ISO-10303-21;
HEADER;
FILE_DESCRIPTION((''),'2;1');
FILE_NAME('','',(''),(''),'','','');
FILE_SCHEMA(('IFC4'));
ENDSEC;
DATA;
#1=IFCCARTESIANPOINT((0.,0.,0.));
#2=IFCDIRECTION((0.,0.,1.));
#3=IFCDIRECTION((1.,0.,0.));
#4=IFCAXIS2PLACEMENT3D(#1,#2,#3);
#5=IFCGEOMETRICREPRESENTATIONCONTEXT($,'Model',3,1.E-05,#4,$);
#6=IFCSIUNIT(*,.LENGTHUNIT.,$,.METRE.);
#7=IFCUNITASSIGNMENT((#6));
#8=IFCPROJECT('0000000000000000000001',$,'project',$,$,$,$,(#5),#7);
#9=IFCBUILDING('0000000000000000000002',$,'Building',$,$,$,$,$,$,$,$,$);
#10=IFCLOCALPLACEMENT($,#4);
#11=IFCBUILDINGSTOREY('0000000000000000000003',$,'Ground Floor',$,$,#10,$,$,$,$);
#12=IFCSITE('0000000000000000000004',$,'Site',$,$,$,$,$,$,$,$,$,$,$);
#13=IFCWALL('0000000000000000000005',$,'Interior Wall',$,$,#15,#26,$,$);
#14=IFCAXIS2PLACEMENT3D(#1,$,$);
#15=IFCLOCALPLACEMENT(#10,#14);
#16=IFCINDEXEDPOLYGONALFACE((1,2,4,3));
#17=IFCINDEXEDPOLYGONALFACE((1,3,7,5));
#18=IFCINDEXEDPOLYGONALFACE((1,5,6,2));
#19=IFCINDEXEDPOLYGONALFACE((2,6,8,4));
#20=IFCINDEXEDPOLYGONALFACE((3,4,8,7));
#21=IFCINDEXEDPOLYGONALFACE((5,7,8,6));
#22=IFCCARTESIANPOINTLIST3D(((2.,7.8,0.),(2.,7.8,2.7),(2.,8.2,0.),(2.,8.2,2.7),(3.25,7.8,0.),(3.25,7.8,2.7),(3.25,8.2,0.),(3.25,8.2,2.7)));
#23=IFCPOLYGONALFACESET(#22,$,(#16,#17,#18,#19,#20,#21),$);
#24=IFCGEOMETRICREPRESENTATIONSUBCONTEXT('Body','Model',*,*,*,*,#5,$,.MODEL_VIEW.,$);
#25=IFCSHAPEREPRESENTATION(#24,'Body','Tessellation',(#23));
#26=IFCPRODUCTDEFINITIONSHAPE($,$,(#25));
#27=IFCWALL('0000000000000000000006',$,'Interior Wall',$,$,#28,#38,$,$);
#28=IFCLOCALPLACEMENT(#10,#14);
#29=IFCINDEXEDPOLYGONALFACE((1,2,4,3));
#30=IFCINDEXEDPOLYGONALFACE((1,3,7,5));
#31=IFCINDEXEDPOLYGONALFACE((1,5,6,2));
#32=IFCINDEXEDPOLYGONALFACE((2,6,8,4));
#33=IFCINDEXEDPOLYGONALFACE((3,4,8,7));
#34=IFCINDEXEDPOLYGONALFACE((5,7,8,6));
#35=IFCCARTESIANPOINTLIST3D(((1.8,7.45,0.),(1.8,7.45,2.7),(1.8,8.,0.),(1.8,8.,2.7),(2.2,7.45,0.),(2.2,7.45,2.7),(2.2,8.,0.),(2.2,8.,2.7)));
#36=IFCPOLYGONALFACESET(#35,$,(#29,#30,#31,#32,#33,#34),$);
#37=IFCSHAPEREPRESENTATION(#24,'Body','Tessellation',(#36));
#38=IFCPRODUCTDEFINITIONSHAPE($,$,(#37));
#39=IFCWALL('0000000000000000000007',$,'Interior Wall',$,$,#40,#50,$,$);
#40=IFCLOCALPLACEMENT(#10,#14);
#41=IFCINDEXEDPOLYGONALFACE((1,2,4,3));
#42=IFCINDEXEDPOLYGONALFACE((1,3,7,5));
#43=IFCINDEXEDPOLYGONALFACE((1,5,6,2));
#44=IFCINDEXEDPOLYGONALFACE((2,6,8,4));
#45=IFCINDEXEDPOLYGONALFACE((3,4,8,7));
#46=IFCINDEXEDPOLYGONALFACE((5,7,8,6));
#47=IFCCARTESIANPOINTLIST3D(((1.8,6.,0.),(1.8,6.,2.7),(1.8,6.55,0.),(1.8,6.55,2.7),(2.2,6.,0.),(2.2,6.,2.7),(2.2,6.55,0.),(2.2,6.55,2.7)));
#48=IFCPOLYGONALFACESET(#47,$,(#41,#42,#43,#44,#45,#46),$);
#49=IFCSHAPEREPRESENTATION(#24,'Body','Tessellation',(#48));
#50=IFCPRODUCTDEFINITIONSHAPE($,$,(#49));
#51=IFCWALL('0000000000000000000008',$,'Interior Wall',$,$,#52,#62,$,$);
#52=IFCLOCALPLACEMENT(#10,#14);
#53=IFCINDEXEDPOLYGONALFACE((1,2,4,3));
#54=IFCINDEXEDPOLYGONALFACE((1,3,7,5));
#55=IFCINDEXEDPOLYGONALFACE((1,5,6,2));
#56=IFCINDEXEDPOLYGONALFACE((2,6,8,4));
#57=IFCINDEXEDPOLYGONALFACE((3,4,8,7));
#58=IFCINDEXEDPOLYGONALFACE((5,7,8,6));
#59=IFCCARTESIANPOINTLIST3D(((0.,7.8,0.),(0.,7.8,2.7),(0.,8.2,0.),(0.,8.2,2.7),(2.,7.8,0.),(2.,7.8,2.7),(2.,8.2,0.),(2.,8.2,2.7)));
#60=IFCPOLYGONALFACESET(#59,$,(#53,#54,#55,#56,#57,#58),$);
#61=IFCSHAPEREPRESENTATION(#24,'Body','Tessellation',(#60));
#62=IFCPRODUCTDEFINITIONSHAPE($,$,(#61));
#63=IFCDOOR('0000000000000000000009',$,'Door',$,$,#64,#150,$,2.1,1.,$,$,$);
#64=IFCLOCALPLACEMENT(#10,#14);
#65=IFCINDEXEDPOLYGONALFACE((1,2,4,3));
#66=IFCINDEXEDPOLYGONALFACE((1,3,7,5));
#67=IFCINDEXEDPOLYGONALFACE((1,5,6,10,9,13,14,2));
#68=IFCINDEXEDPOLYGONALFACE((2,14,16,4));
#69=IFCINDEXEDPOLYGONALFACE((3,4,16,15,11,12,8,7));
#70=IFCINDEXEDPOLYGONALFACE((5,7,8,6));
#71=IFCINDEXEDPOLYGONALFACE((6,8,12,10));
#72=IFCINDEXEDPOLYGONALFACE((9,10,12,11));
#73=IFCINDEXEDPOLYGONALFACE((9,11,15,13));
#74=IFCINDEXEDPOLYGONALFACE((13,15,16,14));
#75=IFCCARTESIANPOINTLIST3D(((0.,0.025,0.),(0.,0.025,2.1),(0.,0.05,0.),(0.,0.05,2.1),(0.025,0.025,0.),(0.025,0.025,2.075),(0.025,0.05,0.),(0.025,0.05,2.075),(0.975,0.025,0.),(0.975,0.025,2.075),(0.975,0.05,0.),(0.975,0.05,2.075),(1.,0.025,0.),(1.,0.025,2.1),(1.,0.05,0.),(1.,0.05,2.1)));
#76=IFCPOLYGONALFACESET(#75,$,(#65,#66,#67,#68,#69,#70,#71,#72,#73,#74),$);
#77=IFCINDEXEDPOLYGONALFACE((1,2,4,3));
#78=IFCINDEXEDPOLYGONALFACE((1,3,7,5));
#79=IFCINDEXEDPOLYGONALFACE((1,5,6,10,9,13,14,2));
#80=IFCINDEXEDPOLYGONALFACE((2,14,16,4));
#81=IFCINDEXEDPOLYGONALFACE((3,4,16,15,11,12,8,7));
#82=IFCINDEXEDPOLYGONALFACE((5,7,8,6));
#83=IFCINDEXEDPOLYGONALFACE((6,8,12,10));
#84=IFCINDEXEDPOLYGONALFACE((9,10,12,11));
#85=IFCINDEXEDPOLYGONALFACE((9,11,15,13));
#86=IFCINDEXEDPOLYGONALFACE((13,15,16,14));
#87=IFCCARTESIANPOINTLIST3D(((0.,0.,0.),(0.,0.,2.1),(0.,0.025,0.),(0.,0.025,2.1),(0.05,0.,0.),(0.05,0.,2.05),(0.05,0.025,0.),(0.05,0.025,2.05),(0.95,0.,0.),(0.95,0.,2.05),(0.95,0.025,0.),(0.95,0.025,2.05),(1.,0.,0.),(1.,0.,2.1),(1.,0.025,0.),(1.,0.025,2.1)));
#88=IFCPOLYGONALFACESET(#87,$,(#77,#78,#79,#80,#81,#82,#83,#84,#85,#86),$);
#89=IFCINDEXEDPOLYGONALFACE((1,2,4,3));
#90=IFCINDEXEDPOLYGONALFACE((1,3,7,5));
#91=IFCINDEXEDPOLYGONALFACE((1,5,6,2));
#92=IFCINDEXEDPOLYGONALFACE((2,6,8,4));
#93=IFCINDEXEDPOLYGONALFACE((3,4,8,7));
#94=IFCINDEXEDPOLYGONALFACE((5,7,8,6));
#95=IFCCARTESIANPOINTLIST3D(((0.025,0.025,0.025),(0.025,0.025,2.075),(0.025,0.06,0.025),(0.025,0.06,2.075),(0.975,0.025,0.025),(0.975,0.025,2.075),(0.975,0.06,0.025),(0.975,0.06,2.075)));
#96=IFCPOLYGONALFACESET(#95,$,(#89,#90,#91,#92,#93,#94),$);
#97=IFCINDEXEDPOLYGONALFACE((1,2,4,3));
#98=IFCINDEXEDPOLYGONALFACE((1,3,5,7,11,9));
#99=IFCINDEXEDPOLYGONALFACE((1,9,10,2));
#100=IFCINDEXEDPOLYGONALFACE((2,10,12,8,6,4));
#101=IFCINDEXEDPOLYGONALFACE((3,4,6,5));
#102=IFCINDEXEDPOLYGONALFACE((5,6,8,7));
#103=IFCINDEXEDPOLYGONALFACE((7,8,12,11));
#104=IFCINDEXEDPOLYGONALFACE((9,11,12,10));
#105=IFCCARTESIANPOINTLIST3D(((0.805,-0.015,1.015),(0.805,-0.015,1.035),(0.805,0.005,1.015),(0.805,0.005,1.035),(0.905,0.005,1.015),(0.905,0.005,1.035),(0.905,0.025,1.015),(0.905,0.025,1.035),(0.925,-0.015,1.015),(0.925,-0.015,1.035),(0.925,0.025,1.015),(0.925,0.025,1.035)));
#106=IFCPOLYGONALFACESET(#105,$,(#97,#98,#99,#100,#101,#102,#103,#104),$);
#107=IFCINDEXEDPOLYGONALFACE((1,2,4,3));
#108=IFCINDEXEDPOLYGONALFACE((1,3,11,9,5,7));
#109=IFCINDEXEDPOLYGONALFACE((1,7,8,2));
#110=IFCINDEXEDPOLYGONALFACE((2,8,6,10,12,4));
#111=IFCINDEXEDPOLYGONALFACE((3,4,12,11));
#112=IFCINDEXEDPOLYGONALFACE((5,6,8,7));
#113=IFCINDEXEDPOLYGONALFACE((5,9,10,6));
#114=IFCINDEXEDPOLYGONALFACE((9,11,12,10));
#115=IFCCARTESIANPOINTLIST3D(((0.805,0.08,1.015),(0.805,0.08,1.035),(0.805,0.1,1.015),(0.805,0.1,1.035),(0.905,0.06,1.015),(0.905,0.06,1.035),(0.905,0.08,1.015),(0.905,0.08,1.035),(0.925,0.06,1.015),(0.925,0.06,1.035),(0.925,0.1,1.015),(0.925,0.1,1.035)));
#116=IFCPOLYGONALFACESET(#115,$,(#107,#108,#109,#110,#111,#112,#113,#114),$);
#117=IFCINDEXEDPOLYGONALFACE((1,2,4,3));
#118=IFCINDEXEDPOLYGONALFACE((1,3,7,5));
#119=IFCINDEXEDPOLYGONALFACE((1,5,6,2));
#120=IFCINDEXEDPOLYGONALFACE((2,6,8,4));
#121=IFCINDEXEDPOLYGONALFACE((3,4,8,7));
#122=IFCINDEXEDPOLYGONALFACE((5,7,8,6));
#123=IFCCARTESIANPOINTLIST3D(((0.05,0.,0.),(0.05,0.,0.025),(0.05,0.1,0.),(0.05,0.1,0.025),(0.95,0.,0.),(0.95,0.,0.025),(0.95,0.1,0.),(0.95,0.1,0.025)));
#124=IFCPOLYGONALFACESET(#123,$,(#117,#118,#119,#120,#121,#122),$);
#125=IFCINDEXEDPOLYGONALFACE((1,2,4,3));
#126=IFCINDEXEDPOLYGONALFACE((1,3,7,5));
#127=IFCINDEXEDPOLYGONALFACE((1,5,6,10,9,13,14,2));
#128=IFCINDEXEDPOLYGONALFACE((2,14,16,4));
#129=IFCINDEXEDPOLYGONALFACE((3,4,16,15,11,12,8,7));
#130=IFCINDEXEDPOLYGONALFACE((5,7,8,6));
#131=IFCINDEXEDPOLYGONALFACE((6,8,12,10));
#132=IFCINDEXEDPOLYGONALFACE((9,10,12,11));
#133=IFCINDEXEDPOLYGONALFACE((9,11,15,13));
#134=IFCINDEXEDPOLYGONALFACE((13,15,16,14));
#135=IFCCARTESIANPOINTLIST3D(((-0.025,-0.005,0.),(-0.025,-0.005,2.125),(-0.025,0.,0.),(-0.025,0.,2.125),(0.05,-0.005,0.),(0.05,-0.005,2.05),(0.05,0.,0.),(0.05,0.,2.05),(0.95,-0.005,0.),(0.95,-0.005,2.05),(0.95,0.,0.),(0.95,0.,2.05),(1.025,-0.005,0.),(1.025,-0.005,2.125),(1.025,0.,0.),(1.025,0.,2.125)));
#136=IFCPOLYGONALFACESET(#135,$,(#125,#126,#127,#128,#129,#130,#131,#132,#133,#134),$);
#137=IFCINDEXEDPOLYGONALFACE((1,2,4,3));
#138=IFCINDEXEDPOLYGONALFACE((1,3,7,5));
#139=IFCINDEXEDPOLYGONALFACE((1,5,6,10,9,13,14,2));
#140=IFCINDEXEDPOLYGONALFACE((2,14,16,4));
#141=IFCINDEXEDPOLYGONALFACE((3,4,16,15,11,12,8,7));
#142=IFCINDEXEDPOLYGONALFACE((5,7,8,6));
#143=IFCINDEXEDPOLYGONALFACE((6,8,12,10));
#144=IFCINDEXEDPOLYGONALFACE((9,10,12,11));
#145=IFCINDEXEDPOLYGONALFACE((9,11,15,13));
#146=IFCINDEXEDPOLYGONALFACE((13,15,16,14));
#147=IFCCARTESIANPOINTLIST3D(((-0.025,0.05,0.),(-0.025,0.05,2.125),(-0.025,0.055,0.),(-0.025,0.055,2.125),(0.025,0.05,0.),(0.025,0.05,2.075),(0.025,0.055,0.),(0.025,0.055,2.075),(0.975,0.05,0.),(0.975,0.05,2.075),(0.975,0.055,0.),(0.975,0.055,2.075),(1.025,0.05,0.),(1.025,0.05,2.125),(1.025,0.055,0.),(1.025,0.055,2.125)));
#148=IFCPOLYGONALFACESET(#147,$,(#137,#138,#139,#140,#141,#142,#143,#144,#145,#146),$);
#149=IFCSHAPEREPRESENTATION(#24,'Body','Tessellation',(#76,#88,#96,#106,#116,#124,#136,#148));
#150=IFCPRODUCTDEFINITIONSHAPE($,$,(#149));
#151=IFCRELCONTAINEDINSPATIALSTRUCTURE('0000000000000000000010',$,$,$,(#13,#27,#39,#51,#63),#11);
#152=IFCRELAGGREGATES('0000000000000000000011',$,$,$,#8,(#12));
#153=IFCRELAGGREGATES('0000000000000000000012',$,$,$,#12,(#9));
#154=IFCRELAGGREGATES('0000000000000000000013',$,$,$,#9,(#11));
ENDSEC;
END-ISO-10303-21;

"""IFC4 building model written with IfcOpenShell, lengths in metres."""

from ifc_helpers import new_model, si_unit, frame, origin_with_axes, place, context, subcontext, project, spatial, line, indexed_curve, outline, extrude, element, save


model = new_model("IFC4")

# Units and contexts
model_context = context("Model", 3, precision=1e-05, world=origin_with_axes())
body_context = subcontext(model_context, "Body", "Model", "MODEL_VIEW")
ifc_project = project(units=[si_unit("LENGTHUNIT", "METRE")], contexts=[model_context])

# Site, building, storey
site = spatial("IfcSite", under=ifc_project, Name="Site")
building = spatial("IfcBuilding", under=site, Name="Building")
storey_placement = place(None, origin_with_axes())
storey = spatial("IfcBuildingStorey", under=building, at=storey_placement, Name="Ground Floor")

# Walls
wall_1_placement = place(storey_placement, frame((3.25, 8.0, 0.0), z_axis=(0.0, 0.0, 1.0), x_axis=(-1.0, 0.0, 0.0)))
element("IfcWall", 1, at=wall_1_placement, inside=storey, Name="Interior Wall", context=body_context, shape_type="SweptSolid", body=[
    extrude(outline(indexed_curve([(0.0, 0.0), (0.0, 0.4), (1.25, 0.4), (1.25, 0.0), (0.0, 0.0)], self_intersect=False)), frame((0.0, -0.2, 0.0), z_axis=(0.0, 0.0, 1.0), x_axis=(1.0, 0.0, 0.0)), (0.0, 0.0, 1.0), 2.7),
])
for number, where, z_axis, x_axis, name in (
    (2, (2.0, 8.0, 0.0), (0.0, 0.0, 1.0), (0.0, -1.0, 0.0), "Interior Wall"),
    (3, (2.0, 6.55, 0.0), (0.0, 0.0, 1.0), (0.0, -1.0, 0.0), "Interior Wall"),
):
    element("IfcWall", number, at=place(storey_placement, frame(where, z_axis=z_axis, x_axis=x_axis)), inside=storey, Name=name, context=body_context, shape_type="SweptSolid", body=[
        extrude(outline(indexed_curve([(0.0, 0.0), (0.0, 0.4), (0.55, 0.4), (0.55, 0.0), (0.0, 0.0)], self_intersect=False)), frame((0.0, -0.2, 0.0), z_axis=(0.0, 0.0, 1.0), x_axis=(1.0, 0.0, 0.0)), (0.0, 0.0, 1.0), 2.7),
    ])
wall_2_placement = place(storey_placement, frame((2.0, 8.0, 0.0), z_axis=(0.0, 0.0, 1.0), x_axis=(-1.0, 0.0, 0.0)))
element("IfcWall", 4, at=wall_2_placement, inside=storey, Name="Interior Wall", context=body_context, shape_type="SweptSolid", body=[
    extrude(outline(indexed_curve([(0.0, 0.0), (0.0, 0.4), (2.0, 0.4), (2.0, 0.0), (0.0, 0.0)], self_intersect=False)), frame((0.0, -0.2, 0.0), z_axis=(0.0, 0.0, 1.0), x_axis=(1.0, 0.0, 0.0)), (0.0, 0.0, 1.0), 2.7),
])

# Door
door_1_placement = place(storey_placement, origin_with_axes())
element("IfcDoor", 5, at=door_1_placement, inside=storey, Name="Door", OverallHeight=2.1, OverallWidth=1.0, context=body_context, shape_type="SweptSolid", body=[
    extrude(outline(indexed_curve([(0.0, 0.0), (0.0, 2.1), (1.0, 2.1), (1.0, 0.0), (0.975, 0.0), (0.975, 2.075), (0.025, 2.075), (0.025, 0.0)], segments=[line(1, 2, 3, 4, 5, 6, 7, 8, 1)])), frame((0.0, 0.025, 0.0), z_axis=(0.0, -1.0, 0.0), x_axis=(1.0, 0.0, 0.0)), (0.0, 0.0, -1.0), 0.025),
    extrude(outline(indexed_curve([(0.0, 0.0), (0.0, 2.1), (1.0, 2.1), (1.0, 0.0), (0.95, 0.0), (0.95, 2.05), (0.05, 2.05), (0.05, 0.0)], segments=[line(1, 2, 3, 4, 5, 6, 7, 8, 1)])), frame((0.0, 0.0, 0.0), z_axis=(0.0, -1.0, 0.0), x_axis=(1.0, 0.0, 0.0)), (0.0, 0.0, -1.0), 0.025),
    extrude(outline(indexed_curve([(0.0, 0.0), (0.95, 0.0), (0.95, 0.035), (0.0, 0.035)], segments=[line(1, 2, 3, 4, 1)])), frame((0.025, 0.025, 0.025), z_axis=(0.0, 0.0, 1.0), x_axis=(1.0, 0.0, 0.0)), (0.0, 0.0, 1.0), 2.05),
    extrude(outline(indexed_curve([(0.0, 0.0), (0.0, -0.04), (-0.12, -0.04), (-0.12, -0.02), (-0.02, -0.02), (-0.02, 0.0)], segments=[line(1, 2, 3, 4, 5, 6, 1)])), frame((0.925, 0.025, 1.015), z_axis=(0.0, 0.0, 1.0), x_axis=(1.0, 0.0, 0.0)), (0.0, 0.0, 1.0), 0.02),
    extrude(outline(indexed_curve([(0.0, 0.0), (0.0, 0.04), (-0.12, 0.04), (-0.12, 0.02), (-0.02, 0.02), (-0.02, 0.0)], segments=[line(1, 2, 3, 4, 5, 6, 1)])), frame((0.925, 0.06, 1.015), z_axis=(0.0, 0.0, 1.0), x_axis=(1.0, 0.0, 0.0)), (0.0, 0.0, 1.0), 0.02),
    extrude(outline(indexed_curve([(0.0, 0.0), (0.9, 0.0), (0.9, 0.1), (0.0, 0.1)], segments=[line(1, 2, 3, 4, 1)])), frame((0.05, 0.0, 0.0), z_axis=(0.0, 0.0, 1.0), x_axis=(1.0, 0.0, 0.0)), (0.0, 0.0, 1.0), 0.025),
    extrude(outline(indexed_curve([(0.0, 0.0), (0.0, 2.125), (1.05, 2.125), (1.05, 0.0), (0.975, 0.0), (0.975, 2.05), (0.075, 2.05), (0.075, 0.0)], segments=[line(1, 2, 3, 4, 5, 6, 7, 8, 1)])), frame((-0.025, -0.005, 0.0), z_axis=(0.0, -1.0, 0.0), x_axis=(1.0, 0.0, 0.0)), (0.0, 0.0, -1.0), 0.005),
    extrude(outline(indexed_curve([(0.0, 0.0), (0.0, 2.125), (1.05, 2.125), (1.05, 0.0), (1.0, 0.0), (1.0, 2.075), (0.05, 2.075), (0.05, 0.0)], segments=[line(1, 2, 3, 4, 5, 6, 7, 8, 1)])), frame((-0.025, 0.05, 0.0), z_axis=(0.0, -1.0, 0.0), x_axis=(1.0, 0.0, 0.0)), (0.0, 0.0, -1.0), 0.005),
])

save(model, "model.ifc")
